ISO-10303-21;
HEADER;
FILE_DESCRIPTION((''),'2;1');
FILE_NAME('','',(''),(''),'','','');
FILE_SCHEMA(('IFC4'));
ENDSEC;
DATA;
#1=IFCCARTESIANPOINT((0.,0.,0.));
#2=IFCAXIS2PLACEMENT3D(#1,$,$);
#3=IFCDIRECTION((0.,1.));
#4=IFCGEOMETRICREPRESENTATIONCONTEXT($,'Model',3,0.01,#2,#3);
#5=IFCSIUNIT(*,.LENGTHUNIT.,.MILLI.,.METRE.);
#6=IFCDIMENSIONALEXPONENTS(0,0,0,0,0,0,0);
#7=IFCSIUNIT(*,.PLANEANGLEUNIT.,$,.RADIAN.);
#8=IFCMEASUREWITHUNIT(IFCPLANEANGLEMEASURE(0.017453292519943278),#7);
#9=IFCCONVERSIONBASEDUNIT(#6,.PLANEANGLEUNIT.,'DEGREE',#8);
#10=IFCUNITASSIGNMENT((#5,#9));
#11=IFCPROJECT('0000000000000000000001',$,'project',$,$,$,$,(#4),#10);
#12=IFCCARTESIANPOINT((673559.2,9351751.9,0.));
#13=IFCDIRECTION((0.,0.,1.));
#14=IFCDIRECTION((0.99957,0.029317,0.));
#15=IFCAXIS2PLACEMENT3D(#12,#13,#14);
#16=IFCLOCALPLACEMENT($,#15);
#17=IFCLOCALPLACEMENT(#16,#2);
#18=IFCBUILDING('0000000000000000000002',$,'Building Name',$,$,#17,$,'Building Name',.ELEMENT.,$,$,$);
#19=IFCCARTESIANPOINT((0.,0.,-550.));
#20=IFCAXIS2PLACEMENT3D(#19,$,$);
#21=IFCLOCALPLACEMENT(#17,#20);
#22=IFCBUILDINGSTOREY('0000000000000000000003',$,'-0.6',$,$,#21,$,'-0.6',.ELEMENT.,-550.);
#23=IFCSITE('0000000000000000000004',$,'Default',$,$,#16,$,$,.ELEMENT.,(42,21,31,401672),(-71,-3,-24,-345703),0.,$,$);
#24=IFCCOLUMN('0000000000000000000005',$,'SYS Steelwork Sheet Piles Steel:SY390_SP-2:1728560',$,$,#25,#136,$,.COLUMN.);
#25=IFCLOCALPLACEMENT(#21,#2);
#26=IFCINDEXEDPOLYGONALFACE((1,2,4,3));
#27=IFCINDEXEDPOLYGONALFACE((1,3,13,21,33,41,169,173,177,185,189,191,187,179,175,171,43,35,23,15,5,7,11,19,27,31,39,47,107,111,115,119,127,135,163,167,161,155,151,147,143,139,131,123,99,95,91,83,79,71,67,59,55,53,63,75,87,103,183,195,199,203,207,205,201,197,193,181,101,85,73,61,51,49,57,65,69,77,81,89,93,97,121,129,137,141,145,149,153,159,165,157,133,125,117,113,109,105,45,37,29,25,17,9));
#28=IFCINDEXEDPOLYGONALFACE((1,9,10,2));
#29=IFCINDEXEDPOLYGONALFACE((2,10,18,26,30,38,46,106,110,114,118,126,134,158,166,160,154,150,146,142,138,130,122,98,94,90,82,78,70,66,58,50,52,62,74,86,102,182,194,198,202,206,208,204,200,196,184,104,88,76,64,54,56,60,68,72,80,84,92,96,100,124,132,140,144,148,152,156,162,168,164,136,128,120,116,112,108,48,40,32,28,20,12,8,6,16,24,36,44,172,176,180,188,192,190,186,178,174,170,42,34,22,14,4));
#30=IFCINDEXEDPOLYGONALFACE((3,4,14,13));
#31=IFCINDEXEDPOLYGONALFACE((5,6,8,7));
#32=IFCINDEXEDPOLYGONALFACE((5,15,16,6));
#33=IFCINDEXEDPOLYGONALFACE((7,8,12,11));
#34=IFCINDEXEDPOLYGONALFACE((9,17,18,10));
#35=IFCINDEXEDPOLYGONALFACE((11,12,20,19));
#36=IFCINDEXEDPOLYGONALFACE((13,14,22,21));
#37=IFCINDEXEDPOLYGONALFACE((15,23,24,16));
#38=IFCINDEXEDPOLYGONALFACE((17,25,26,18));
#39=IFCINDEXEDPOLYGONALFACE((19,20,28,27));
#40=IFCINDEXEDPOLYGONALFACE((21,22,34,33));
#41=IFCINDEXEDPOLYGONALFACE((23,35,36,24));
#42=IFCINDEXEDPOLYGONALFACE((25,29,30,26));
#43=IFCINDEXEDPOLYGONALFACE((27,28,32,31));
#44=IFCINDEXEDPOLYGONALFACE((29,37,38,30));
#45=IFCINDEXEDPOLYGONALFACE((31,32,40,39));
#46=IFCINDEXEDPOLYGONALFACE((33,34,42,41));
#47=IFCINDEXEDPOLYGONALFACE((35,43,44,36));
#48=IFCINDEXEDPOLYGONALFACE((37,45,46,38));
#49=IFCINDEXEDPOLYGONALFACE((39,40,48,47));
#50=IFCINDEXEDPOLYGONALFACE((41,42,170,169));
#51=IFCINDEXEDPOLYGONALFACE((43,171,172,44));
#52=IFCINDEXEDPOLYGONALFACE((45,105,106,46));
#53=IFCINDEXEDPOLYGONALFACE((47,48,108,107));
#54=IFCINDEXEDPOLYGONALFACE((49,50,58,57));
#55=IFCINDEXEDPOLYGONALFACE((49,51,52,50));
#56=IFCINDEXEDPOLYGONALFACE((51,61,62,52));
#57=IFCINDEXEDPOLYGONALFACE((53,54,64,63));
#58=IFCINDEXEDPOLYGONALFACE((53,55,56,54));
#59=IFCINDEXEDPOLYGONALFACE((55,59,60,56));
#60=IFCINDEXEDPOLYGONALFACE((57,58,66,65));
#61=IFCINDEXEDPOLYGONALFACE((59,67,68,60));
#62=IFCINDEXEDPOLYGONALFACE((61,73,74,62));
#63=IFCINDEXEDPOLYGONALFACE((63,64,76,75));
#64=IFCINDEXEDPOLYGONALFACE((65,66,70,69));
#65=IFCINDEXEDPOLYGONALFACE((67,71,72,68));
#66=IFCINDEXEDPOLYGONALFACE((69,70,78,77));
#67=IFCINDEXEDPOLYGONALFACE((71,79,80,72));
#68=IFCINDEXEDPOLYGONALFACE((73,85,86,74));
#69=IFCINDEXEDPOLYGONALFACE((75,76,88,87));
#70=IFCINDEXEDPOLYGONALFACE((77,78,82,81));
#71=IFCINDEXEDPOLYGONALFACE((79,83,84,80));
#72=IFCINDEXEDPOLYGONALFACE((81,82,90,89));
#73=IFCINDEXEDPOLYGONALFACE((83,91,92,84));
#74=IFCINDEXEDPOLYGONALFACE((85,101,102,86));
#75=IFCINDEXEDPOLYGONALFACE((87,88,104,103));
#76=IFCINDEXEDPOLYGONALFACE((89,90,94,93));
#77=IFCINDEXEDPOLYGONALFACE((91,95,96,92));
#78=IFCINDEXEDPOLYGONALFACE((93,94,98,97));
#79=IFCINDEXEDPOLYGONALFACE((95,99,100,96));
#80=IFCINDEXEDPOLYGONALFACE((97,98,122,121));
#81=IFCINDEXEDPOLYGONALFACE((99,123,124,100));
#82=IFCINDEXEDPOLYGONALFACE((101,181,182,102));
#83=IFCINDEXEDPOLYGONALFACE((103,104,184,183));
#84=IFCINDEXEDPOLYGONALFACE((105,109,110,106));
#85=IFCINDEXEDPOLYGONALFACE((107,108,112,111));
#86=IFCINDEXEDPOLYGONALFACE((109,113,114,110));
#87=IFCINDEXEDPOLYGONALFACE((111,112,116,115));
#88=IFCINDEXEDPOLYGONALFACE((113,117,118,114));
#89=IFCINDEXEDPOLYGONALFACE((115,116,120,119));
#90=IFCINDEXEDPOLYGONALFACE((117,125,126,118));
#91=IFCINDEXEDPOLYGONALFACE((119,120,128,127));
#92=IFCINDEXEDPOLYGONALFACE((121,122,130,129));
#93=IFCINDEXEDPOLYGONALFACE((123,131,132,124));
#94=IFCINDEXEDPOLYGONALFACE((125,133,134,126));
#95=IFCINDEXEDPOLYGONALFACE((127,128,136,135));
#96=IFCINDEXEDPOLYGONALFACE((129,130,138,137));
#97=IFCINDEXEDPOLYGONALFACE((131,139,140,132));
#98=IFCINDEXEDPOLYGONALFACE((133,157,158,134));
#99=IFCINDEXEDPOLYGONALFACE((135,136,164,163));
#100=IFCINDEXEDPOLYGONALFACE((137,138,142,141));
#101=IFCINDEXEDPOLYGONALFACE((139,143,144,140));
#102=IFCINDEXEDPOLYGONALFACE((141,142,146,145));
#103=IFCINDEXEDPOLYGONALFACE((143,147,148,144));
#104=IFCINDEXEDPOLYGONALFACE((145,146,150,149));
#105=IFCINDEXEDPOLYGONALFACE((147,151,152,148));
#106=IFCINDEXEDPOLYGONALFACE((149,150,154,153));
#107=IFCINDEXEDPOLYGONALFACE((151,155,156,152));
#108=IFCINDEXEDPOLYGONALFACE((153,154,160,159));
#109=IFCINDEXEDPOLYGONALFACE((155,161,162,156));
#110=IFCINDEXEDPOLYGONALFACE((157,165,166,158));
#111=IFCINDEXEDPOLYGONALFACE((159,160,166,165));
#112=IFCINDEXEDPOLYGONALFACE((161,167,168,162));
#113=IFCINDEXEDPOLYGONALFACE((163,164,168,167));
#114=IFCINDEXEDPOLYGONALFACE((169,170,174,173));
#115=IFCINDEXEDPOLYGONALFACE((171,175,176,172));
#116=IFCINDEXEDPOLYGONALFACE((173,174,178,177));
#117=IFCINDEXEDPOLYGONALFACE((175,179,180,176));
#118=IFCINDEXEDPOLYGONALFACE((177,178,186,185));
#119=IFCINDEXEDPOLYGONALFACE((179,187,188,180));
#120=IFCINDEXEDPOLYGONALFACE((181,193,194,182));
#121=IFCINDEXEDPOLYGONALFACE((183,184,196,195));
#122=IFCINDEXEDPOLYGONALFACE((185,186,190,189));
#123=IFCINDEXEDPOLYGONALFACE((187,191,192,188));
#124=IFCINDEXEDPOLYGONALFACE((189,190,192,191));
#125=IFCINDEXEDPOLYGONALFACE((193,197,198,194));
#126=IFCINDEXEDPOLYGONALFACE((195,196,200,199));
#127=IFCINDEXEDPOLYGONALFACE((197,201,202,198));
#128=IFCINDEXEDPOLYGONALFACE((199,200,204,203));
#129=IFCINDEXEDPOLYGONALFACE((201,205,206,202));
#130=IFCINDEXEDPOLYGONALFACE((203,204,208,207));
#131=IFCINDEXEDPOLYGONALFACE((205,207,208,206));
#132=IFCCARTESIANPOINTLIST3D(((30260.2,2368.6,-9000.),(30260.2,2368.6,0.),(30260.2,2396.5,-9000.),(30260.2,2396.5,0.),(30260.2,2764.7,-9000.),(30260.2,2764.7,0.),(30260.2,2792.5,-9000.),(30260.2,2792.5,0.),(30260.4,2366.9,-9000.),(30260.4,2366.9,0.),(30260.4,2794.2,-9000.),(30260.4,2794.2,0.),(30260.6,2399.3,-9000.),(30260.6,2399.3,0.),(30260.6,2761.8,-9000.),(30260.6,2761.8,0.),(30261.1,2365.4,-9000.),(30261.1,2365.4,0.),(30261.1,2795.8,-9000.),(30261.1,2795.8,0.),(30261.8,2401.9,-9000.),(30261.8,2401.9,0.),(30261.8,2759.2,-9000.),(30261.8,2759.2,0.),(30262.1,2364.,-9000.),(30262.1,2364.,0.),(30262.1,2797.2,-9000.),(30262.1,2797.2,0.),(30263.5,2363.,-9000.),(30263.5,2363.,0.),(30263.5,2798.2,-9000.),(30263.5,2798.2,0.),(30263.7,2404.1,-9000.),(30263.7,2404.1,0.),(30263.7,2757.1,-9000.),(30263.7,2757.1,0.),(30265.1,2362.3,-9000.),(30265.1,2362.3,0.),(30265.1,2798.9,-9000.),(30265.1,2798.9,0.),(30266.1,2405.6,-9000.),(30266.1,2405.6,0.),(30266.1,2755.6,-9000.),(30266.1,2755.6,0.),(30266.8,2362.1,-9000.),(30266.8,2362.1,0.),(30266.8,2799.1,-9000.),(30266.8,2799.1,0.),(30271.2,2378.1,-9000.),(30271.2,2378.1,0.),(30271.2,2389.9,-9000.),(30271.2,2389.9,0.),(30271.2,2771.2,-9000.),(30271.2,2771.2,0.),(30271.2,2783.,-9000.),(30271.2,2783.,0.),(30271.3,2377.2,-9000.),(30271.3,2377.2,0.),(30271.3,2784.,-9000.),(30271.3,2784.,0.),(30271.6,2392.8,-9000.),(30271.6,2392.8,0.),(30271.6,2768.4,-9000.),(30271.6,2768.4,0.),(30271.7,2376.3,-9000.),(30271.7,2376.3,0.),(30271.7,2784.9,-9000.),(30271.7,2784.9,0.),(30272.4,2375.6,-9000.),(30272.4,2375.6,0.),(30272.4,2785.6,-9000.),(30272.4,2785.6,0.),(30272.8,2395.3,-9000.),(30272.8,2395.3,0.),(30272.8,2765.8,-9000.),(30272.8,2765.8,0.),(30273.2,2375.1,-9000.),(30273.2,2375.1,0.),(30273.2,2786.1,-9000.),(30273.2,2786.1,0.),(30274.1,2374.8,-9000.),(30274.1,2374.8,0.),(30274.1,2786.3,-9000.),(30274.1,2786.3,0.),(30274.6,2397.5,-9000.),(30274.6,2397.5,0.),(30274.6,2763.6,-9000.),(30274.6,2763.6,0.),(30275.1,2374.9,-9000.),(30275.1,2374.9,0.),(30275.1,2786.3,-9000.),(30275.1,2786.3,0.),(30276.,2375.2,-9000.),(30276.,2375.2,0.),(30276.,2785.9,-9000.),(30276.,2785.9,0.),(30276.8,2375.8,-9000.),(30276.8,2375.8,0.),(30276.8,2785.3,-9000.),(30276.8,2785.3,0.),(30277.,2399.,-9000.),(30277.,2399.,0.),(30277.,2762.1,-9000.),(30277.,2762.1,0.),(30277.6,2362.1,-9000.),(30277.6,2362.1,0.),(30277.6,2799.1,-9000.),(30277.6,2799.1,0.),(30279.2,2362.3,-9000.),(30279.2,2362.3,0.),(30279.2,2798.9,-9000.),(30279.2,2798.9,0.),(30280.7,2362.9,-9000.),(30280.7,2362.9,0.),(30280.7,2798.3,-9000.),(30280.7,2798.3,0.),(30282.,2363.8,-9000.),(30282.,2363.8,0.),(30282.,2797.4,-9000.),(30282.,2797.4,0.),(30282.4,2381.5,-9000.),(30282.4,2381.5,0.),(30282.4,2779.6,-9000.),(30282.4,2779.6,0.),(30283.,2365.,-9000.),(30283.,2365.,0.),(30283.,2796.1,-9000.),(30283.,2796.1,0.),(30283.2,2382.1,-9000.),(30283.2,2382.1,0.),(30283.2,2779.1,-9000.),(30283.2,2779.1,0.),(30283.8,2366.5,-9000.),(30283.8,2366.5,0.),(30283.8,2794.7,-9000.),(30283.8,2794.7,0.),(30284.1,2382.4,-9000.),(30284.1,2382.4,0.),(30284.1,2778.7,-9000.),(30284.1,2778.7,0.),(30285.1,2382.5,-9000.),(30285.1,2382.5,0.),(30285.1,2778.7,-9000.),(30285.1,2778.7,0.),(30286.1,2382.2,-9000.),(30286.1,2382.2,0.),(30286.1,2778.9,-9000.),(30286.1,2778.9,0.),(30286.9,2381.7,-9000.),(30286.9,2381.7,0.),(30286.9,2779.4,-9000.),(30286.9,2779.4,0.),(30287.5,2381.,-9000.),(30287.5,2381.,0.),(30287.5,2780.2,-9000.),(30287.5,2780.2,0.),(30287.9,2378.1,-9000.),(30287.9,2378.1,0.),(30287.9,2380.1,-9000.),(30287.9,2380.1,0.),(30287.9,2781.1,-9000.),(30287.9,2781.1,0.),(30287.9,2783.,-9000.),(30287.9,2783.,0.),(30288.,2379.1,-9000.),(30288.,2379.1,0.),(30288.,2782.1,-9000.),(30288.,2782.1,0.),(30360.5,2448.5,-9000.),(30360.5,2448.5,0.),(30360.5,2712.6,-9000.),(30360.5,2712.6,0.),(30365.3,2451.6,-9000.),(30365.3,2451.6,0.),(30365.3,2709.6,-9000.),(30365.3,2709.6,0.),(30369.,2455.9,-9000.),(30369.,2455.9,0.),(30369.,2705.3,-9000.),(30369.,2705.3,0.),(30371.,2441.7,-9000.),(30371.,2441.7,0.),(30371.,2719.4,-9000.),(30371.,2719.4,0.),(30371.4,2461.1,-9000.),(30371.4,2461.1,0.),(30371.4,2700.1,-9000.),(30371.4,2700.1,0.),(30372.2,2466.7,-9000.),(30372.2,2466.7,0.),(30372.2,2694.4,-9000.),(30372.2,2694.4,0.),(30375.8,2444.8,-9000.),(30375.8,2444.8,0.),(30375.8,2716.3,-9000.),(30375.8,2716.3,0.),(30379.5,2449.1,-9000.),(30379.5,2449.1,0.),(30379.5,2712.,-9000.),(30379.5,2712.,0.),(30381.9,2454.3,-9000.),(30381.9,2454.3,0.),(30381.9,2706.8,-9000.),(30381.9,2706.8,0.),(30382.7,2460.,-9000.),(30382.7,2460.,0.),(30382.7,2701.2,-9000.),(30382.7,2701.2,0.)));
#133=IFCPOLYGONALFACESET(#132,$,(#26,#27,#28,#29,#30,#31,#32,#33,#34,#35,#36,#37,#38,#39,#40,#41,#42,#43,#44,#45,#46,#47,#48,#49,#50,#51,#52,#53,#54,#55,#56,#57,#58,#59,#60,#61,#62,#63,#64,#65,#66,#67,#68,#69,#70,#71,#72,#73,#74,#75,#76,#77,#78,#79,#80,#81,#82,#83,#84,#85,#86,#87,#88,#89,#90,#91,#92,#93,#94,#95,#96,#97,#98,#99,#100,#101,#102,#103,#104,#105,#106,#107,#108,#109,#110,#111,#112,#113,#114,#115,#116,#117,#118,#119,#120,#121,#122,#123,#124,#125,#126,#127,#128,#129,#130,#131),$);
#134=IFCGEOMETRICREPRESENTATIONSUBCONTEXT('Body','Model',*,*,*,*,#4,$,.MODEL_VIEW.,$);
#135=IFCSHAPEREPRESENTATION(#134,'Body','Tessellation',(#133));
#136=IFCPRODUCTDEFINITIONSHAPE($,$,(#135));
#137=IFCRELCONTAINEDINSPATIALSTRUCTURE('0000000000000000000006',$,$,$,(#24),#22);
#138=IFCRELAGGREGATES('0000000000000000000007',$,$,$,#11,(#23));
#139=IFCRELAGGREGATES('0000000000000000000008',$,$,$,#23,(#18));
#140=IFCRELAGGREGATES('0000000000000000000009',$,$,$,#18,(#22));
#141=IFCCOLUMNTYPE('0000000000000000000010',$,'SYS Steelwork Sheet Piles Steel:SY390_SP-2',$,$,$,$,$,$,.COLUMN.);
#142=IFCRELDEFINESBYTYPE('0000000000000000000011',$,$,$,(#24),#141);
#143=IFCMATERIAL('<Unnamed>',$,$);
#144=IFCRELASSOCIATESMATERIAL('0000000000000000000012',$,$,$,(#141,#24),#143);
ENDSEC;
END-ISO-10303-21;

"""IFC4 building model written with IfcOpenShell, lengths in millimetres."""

from ifc_helpers import new_model, entity, si_unit, converted_unit, direction, frame, origin, place, context, subcontext, project, spatial, line, arc, indexed_curve, outline, extrude, source, transform, mapped, material, type_object, type_shapes, element, save


model = new_model("IFC4")

# Units and contexts
model_context = context("Model", 3, precision=0.01, world=origin(), true_north=direction((0.0, 1.0)))
body_context = subcontext(model_context, "Body", "Model", "MODEL_VIEW")
ifc_project = project(units=[si_unit("LENGTHUNIT", "METRE", prefix="MILLI"), converted_unit("PLANEANGLEUNIT", "DEGREE", entity("IfcPlaneAngleMeasure", 0.017453292519943278), si_unit("PLANEANGLEUNIT", "RADIAN"), dimensions=[0, 0, 0, 0, 0, 0, 0])], contexts=[model_context])

# Site, building, storey
site_placement = place(None, frame((673559.2, 9351751.9, 0.0), z_axis=(0.0, 0.0, 1.0), x_axis=(0.99957, 0.029317, 0.0)))
site = spatial("IfcSite", under=ifc_project, at=site_placement, Name="Default", CompositionType="ELEMENT", RefLatitude=(42, 21, 31, 401672), RefLongitude=(-71, -3, -24, -345703), RefElevation=0.0)
building_placement = place(site_placement, origin())
building = spatial("IfcBuilding", under=site, at=building_placement, Name="Building Name", LongName="Building Name", CompositionType="ELEMENT")
storey_placement = place(building_placement, frame((0.0, 0.0, -550.0)))
storey = spatial("IfcBuildingStorey", under=building, at=storey_placement, Name="-0.6", LongName="-0.6", CompositionType="ELEMENT", Elevation=-550.0)

# Column
ifc_material_1 = material(Name="<Unnamed>")
column_type = type_object("IfcColumnType", Name="SYS Steelwork Sheet Piles Steel:SY390_SP-2", PredefinedType="COLUMN", material=ifc_material_1)
shared_shape_1 = source(origin(), body_context, "Body", "SweptSolid", [
    extrude(outline(indexed_curve([(-120.6, 84.7), (-131.4, 81.6), (-138.8, 73.0), (-181.5, -20.9), (-185.2, -25.2), (-190.6, -26.8), (-202.5, -26.8), (-205.5, -24.8), (-204.8, -21.2), (-199.1, -15.5), (-198.6, -11.5), (-202.5, -10.1), (-214.1, -14.2), (-217.3, -16.6), (-218.5, -20.4), (-218.5, -31.2), (-216.6, -35.8), (-211.9, -37.8), (-184.1, -37.8), (-178.7, -36.2), (-175.0, -31.9), (-132.1, 62.5), (-124.7, 71.1), (-113.9, 74.2), (113.9, 74.2), (124.7, 71.1), (132.1, 62.5), (175.0, -31.9), (178.7, -36.2), (184.1, -37.8), (211.9, -37.8), (216.6, -35.8), (218.5, -31.2), (218.5, -20.4), (217.3, -16.6), (214.1, -14.2), (202.5, -10.1), (198.6, -11.5), (199.1, -15.5), (204.8, -21.2), (205.5, -24.8), (202.5, -26.8), (190.6, -26.8), (185.2, -25.2), (181.5, -20.9), (138.8, 73.0), (131.4, 81.6), (120.6, 84.7)], segments=[arc(1, 2, 3), line(3, 4), arc(4, 5, 6), line(6, 7), arc(7, 8, 9), line(9, 10), arc(10, 11, 12), line(12, 13), arc(13, 14, 15), line(15, 16), arc(16, 17, 18), line(18, 19), arc(19, 20, 21), line(21, 22), arc(22, 23, 24), line(24, 25), arc(25, 26, 27), line(27, 28), arc(28, 29, 30), line(30, 31), arc(31, 32, 33), line(33, 34), arc(34, 35, 36), line(36, 37), arc(37, 38, 39), line(39, 40), arc(40, 41, 42), line(42, 43), arc(43, 44, 45), line(45, 46), arc(46, 47, 48), line(48, 1)], self_intersect=False)), frame((0.0, 15.3, -9550.0)), (0.0, 0.0, 1.0), 9000.0),
])
type_shapes(column_type, [shared_shape_1])
for number, where, z_axis, x_axis, name in (
    (1, (30282.7, 2580.6, 550.0), (0.0, 0.0, 1.0), (0.0, -1.0, 0.0), "SYS Steelwork Sheet Piles Steel:SY390_SP-2:1728560"),
):
    element("IfcColumn", number, at=place(storey_placement, frame(where, z_axis=z_axis, x_axis=x_axis)), inside=storey, type_object=column_type, material=ifc_material_1, Name=name, PredefinedType="COLUMN", context=body_context, shape_type="MappedRepresentation", body=[
        mapped(shared_shape_1, transform((0.0, 0.0, 0.0), scale=1.0)),
    ])

save(model, "model.ifc")
